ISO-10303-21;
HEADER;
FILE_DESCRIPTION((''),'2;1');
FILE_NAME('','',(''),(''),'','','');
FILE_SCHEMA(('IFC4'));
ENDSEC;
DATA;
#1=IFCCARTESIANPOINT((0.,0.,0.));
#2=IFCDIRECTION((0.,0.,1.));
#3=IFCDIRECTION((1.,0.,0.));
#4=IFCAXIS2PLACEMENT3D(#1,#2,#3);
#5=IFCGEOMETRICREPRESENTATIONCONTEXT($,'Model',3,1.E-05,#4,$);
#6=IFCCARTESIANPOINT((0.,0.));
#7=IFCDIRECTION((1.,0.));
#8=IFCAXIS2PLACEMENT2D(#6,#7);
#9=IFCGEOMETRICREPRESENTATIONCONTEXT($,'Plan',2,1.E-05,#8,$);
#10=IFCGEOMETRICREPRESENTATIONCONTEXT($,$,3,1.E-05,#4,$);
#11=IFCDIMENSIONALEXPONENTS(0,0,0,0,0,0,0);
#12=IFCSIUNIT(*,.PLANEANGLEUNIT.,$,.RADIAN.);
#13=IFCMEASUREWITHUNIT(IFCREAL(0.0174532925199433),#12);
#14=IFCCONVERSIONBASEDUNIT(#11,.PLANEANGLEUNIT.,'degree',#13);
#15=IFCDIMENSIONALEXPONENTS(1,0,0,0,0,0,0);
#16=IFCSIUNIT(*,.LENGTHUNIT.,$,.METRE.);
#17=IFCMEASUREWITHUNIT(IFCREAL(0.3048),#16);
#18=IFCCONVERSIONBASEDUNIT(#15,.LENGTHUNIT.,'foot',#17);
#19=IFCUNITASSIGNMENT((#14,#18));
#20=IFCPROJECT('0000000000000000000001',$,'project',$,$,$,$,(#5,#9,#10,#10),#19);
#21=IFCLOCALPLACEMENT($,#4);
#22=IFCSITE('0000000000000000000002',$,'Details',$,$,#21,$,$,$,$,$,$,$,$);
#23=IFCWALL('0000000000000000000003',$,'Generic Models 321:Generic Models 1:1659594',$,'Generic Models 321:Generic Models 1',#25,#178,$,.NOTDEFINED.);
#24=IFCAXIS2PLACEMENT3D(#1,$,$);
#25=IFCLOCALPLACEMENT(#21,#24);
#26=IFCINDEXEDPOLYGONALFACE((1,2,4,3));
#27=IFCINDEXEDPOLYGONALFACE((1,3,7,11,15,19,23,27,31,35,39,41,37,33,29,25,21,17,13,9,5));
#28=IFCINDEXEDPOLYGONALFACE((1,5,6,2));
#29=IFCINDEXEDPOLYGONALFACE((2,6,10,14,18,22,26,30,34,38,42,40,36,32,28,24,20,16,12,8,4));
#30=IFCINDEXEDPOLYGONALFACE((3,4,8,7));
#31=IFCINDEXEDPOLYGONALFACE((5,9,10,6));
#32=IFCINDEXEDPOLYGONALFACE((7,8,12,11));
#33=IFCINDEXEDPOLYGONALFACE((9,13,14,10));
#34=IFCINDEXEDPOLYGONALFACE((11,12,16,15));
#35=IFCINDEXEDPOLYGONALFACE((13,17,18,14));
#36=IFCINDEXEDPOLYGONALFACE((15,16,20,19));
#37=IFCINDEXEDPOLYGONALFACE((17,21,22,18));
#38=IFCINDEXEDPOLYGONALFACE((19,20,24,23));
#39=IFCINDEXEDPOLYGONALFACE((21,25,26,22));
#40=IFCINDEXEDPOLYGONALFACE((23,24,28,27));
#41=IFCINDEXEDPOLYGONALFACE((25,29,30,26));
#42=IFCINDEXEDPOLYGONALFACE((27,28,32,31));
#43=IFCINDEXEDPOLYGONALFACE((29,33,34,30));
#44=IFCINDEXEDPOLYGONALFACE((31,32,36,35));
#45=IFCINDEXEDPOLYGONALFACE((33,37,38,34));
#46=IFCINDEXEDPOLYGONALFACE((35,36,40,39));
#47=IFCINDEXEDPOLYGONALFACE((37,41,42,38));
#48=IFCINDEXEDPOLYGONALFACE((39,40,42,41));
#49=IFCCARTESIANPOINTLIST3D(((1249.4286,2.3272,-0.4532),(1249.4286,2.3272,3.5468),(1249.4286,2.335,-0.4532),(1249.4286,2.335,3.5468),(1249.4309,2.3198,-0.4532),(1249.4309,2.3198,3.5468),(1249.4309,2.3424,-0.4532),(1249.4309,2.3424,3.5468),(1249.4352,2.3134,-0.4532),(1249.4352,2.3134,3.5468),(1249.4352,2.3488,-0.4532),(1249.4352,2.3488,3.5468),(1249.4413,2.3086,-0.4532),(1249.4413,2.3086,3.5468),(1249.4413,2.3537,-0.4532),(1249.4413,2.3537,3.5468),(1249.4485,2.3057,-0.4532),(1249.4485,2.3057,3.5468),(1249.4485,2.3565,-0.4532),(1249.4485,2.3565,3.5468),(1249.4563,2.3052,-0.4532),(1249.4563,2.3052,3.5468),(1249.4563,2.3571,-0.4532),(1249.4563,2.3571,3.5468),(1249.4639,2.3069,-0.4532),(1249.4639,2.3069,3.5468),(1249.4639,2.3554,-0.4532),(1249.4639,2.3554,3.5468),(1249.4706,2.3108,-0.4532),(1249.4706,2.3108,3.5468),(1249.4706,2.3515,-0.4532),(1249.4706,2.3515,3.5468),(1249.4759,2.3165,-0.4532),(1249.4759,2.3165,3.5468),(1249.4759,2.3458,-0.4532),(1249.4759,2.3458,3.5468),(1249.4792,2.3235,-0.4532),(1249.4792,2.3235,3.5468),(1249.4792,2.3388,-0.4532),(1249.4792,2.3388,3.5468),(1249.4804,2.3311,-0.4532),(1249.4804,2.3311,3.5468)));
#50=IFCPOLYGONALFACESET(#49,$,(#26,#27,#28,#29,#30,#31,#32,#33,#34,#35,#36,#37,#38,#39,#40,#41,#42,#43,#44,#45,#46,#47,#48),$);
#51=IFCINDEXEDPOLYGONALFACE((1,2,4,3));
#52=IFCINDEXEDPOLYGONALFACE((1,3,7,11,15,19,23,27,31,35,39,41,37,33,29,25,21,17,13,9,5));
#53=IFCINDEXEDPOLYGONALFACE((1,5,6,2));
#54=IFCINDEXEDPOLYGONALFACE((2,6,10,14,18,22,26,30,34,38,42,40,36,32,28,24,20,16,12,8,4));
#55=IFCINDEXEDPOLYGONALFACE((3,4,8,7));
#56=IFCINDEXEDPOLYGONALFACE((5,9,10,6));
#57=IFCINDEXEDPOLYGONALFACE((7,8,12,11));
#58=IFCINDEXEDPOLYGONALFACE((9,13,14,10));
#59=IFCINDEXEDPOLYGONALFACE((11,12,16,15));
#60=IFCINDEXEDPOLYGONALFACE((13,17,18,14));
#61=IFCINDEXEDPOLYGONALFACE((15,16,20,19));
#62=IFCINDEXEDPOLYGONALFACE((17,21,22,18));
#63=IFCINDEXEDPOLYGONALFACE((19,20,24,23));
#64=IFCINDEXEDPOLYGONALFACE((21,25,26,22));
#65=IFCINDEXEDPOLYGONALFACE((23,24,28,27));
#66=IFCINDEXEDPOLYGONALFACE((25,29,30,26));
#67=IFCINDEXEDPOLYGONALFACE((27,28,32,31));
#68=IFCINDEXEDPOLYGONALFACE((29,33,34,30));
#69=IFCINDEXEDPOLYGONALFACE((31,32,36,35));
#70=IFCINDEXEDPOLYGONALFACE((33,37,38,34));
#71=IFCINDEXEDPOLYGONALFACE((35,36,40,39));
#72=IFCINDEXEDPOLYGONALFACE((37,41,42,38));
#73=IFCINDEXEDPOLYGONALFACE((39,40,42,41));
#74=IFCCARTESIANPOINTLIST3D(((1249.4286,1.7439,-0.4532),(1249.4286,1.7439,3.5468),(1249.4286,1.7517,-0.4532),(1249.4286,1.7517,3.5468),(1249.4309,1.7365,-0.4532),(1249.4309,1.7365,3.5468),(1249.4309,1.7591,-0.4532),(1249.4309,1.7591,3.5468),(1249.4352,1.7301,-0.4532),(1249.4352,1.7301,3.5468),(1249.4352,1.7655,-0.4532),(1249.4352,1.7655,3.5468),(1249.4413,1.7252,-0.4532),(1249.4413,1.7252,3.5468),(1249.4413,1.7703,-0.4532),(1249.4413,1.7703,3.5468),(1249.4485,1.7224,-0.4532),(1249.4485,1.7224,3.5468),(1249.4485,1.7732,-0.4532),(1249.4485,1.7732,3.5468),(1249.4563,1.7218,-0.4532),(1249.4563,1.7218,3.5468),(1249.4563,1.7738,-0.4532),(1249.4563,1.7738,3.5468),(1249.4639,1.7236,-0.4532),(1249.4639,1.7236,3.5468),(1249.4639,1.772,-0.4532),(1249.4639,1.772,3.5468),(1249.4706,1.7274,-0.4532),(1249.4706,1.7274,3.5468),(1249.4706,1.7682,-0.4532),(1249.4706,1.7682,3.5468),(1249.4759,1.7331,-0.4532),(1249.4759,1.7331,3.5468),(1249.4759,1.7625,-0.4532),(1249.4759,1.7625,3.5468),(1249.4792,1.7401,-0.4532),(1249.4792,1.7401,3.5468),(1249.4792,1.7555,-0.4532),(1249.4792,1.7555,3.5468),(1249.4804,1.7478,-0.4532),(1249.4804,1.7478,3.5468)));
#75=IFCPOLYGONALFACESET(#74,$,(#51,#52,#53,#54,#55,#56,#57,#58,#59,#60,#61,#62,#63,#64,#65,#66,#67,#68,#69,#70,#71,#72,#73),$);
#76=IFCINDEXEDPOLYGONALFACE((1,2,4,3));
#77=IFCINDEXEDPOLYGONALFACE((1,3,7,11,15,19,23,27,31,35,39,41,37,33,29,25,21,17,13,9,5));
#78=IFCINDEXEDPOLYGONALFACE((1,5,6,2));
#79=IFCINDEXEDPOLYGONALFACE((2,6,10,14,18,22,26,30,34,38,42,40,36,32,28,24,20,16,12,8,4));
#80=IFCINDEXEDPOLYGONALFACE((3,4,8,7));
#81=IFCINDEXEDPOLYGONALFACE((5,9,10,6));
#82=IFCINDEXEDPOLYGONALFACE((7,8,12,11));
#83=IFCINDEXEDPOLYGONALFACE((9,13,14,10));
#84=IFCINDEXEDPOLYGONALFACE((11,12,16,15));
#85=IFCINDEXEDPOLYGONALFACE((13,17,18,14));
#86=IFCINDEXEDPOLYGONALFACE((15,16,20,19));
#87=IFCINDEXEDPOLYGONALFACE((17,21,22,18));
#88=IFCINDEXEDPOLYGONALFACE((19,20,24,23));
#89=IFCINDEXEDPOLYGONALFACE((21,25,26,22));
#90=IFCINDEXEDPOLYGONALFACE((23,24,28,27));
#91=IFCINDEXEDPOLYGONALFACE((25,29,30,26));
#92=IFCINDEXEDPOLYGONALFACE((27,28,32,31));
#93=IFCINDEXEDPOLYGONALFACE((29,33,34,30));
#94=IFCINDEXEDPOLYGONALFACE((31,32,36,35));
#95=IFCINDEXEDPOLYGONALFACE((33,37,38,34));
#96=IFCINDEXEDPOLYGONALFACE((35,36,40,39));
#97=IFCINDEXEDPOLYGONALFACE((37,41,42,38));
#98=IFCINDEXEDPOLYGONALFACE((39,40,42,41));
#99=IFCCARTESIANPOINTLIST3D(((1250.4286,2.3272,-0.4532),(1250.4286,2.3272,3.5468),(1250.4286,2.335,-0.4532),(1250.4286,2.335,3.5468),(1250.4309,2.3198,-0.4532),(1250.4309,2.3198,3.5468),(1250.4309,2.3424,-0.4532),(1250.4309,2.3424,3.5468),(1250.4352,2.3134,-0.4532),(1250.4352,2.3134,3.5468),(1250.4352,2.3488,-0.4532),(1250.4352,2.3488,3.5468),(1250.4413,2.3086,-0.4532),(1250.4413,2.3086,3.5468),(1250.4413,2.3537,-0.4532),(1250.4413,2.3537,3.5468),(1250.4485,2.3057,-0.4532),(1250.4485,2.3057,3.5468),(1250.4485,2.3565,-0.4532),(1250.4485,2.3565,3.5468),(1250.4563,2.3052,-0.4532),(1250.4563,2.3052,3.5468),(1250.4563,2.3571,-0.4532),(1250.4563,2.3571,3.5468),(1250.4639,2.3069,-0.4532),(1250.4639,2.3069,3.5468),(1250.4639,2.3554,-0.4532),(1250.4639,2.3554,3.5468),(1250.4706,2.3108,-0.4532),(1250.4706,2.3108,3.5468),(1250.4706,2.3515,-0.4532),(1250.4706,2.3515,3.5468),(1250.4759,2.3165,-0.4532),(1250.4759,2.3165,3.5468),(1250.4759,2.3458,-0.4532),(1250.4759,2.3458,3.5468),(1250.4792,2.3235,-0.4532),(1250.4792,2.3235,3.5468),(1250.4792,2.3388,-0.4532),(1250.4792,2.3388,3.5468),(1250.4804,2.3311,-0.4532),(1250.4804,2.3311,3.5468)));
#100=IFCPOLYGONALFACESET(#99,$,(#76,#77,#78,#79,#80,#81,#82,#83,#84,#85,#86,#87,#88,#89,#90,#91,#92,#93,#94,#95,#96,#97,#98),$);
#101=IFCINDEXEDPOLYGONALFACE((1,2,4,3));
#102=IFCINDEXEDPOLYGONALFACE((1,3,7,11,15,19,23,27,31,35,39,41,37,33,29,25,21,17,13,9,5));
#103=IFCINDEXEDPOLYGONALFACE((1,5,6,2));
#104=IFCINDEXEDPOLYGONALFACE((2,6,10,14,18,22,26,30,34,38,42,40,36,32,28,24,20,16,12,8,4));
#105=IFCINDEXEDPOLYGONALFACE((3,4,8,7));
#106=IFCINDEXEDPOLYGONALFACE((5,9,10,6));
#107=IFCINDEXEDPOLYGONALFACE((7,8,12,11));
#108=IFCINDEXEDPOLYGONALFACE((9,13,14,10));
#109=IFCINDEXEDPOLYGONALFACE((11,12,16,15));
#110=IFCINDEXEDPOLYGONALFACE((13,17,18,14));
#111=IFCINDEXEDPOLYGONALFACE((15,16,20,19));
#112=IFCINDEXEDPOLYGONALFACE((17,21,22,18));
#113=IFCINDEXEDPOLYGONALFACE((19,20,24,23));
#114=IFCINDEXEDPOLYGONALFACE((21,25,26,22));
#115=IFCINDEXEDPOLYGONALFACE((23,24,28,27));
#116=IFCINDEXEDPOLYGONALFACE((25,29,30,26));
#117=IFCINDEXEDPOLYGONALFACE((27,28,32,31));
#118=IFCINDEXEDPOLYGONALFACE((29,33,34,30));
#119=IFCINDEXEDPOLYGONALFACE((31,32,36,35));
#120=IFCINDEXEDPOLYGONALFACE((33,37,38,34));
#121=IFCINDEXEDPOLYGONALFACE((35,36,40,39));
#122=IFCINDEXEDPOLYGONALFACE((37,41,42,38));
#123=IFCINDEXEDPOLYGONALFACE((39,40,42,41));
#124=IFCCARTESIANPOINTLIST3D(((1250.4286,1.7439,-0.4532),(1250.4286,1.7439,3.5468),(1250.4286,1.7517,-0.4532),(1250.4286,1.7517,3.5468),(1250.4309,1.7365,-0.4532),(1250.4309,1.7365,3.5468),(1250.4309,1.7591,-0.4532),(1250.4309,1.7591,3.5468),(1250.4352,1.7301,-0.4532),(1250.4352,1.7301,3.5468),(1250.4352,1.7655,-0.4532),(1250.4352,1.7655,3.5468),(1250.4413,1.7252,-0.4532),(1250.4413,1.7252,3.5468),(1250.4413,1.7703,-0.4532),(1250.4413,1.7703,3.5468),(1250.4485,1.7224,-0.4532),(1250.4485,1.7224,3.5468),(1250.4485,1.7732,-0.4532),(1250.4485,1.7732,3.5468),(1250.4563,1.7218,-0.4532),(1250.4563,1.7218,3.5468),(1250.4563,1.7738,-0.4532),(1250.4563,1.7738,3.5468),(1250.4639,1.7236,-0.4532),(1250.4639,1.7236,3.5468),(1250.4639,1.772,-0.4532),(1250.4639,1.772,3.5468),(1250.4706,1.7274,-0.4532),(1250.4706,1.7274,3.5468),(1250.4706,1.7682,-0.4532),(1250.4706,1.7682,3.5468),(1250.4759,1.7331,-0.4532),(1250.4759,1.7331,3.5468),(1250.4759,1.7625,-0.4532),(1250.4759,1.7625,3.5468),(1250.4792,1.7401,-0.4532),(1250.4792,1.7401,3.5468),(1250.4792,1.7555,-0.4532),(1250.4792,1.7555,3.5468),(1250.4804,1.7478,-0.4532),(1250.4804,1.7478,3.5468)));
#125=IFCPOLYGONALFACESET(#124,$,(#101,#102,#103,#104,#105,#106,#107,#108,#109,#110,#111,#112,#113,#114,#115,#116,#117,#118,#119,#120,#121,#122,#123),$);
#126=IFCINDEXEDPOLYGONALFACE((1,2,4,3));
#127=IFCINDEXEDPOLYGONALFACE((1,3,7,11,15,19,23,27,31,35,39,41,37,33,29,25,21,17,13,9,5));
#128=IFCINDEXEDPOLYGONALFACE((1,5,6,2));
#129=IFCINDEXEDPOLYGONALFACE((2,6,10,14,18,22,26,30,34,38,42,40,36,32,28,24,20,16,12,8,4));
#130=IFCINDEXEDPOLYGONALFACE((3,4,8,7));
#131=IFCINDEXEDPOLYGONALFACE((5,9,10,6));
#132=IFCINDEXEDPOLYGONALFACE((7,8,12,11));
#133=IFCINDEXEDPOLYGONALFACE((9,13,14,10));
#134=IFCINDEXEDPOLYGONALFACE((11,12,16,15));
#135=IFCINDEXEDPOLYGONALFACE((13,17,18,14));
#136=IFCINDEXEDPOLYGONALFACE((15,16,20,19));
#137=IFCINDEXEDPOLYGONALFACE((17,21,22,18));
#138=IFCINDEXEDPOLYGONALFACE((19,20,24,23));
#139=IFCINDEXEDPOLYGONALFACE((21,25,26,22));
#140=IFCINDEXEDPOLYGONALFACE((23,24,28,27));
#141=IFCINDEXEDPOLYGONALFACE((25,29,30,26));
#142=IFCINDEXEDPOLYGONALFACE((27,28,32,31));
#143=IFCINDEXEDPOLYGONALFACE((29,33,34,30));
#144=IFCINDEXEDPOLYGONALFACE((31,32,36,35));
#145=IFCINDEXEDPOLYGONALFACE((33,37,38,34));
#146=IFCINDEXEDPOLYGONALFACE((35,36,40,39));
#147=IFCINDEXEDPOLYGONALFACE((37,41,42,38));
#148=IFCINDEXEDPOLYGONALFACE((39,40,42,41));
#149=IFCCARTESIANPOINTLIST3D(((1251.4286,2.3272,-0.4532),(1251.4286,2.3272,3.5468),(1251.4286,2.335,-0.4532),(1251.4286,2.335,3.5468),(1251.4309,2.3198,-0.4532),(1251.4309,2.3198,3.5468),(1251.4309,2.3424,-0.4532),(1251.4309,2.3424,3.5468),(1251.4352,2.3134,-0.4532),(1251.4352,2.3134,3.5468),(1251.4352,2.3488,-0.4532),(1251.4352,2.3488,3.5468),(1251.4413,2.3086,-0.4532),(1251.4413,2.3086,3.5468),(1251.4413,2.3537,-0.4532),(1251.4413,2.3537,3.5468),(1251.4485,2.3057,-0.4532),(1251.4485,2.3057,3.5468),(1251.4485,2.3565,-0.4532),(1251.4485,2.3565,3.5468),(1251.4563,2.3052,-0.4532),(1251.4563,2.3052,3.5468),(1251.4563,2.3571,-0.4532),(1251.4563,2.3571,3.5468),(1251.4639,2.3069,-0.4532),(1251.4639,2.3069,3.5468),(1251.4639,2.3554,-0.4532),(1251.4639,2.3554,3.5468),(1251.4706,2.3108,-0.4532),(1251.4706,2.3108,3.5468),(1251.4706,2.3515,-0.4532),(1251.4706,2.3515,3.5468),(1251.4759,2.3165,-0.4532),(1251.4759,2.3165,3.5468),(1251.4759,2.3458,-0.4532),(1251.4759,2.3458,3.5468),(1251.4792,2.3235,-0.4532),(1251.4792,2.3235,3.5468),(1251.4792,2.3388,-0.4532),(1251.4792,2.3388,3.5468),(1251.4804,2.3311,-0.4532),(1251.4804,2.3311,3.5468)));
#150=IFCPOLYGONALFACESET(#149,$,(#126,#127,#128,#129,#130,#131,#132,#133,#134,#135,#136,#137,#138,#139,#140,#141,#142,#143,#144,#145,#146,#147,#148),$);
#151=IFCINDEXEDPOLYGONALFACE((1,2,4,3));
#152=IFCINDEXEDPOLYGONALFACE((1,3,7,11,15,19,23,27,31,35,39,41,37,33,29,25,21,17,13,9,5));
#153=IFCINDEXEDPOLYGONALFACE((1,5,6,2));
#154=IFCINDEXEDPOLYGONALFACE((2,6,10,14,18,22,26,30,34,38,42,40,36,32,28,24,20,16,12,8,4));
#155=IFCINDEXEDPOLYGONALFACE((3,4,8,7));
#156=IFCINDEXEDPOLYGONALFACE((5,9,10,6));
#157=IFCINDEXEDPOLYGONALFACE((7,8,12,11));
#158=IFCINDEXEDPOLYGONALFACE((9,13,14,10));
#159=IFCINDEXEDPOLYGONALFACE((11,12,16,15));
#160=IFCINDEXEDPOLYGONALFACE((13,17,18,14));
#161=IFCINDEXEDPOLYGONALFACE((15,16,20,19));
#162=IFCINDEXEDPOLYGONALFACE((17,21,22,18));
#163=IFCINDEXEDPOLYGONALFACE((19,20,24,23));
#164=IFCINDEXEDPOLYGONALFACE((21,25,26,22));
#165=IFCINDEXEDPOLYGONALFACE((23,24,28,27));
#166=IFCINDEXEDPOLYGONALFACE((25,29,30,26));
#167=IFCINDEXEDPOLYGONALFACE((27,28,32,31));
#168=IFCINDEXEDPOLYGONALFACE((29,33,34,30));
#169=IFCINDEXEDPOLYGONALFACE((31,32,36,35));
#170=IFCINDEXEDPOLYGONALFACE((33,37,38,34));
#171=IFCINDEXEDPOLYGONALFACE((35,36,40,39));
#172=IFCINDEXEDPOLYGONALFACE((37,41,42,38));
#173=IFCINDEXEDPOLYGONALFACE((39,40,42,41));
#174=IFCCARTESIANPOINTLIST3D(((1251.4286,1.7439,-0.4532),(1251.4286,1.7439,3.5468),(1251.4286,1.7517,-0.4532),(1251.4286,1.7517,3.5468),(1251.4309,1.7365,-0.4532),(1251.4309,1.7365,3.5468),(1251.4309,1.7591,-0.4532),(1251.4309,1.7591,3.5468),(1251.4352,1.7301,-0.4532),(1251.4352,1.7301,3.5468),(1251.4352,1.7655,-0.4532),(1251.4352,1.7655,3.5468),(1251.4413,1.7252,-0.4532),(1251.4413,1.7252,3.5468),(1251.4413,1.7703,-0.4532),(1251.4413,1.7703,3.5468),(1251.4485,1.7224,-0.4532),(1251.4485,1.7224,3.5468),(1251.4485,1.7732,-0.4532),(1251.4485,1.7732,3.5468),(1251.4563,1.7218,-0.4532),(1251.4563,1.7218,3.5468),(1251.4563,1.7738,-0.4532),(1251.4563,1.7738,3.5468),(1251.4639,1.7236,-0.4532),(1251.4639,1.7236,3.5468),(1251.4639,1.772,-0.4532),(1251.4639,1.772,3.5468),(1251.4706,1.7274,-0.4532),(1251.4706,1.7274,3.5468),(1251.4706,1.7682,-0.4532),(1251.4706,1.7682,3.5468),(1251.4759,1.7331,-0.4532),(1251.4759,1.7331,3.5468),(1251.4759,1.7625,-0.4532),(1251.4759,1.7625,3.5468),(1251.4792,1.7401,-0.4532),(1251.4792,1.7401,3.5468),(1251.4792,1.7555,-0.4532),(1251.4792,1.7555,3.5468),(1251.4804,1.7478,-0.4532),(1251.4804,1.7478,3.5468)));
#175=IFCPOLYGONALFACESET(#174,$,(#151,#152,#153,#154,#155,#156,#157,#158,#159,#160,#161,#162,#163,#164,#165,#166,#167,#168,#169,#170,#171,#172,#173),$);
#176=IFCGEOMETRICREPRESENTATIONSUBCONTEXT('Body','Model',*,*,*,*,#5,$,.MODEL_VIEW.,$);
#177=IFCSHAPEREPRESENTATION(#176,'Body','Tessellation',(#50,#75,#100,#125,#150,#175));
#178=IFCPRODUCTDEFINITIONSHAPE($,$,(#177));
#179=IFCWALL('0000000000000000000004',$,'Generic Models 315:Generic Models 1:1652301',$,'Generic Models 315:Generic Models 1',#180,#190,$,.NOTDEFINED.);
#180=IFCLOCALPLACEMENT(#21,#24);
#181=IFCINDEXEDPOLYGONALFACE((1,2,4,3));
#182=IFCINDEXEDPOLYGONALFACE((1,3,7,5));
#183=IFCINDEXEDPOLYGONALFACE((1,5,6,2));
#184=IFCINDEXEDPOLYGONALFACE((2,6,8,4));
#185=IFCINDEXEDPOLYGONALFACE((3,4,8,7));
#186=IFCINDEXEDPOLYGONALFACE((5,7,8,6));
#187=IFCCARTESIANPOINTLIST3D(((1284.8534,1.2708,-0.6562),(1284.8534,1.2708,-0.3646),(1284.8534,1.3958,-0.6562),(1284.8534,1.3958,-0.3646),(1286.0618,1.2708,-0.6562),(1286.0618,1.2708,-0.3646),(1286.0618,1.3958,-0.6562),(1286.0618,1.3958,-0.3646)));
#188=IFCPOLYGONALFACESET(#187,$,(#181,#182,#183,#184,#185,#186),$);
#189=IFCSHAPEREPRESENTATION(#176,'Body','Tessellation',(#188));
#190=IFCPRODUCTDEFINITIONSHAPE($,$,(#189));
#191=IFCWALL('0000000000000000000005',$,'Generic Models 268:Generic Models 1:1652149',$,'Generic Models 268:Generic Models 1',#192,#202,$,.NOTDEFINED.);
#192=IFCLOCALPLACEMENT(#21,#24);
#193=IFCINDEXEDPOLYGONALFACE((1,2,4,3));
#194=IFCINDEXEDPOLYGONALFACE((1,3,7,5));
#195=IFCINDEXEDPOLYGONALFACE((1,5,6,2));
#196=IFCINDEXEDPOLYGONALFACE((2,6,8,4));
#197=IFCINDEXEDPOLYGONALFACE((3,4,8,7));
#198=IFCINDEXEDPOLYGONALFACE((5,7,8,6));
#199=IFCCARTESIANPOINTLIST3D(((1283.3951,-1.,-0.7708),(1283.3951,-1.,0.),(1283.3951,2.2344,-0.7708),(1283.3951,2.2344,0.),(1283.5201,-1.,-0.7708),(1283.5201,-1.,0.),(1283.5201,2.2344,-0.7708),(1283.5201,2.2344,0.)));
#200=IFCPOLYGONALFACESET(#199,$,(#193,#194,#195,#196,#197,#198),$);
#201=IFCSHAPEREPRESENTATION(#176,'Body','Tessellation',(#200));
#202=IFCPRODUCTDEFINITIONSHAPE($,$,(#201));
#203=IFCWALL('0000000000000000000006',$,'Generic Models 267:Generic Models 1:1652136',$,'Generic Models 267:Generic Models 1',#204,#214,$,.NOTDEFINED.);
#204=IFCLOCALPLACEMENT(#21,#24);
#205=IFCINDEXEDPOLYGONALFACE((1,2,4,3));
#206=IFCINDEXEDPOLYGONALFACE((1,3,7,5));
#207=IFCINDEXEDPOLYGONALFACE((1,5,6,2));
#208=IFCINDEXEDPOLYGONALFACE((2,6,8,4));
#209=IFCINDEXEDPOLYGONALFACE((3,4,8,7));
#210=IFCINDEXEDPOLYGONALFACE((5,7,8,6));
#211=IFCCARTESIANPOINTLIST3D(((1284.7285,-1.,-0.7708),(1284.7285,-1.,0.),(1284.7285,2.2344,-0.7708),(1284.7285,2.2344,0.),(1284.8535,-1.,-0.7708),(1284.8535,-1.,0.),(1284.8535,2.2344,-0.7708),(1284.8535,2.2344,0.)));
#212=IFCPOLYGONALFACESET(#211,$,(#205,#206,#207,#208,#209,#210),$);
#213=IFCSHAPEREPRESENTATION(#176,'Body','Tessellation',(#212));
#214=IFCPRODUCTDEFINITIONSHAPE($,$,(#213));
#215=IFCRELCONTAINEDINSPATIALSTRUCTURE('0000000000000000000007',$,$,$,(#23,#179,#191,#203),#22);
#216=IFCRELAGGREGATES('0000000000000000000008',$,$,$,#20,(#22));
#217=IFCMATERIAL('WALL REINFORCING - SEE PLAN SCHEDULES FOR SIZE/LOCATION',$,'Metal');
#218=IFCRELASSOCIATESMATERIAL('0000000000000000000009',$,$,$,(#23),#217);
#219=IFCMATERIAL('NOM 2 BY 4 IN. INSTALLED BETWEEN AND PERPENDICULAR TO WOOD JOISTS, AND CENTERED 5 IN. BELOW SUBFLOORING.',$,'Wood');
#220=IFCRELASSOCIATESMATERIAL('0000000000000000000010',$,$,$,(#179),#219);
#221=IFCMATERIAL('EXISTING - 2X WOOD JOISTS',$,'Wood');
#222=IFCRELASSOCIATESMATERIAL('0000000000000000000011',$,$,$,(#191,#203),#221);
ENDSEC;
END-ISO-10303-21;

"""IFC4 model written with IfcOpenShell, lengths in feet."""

from ifc_helpers import new_model, entity, si_unit, converted_unit, frame, frame_2d, origin_with_axes, origin_2d_with_axis, place, context, subcontext, project, spatial, rectangle, circle, extrude, material, element, save


model = new_model("IFC4")

# Units and contexts
model_context = context("Model", 3, precision=1e-05, world=origin_with_axes())
plan_context = context("Plan", 2, precision=1e-05, world=origin_2d_with_axis())
context_of_model = context(None, 3, precision=1e-05, world=origin_with_axes())
body_context = subcontext(model_context, "Body", "Model", "MODEL_VIEW")
ifc_project = project(units=[converted_unit("PLANEANGLEUNIT", "degree", entity("IfcReal", 0.0174532925199433), si_unit("PLANEANGLEUNIT", "RADIAN"), dimensions=[0, 0, 0, 0, 0, 0, 0]), converted_unit("LENGTHUNIT", "foot", entity("IfcReal", 0.3048), si_unit("LENGTHUNIT", "METRE"), dimensions=[1, 0, 0, 0, 0, 0, 0])], contexts=[model_context, plan_context, context_of_model, context_of_model])

# Site
site_placement = place(None, origin_with_axes())
site = spatial("IfcSite", under=ifc_project, at=site_placement, Name="Details")

# Walls
ifc_material_1 = material(Name="WALL REINFORCING - SEE PLAN SCHEDULES FOR SIZE/LOCATION", Category="Metal")
wall_1_placement = place(site_placement, frame((1249.4283, 1.7218, -0.4532), z_axis=(0.0, 0.0, 1.0), x_axis=(1.0, 0.0, 0.0)))
element("IfcWall", 1, at=wall_1_placement, inside=site, material=ifc_material_1, Name="Generic Models 321:Generic Models 1:1659594", ObjectType="Generic Models 321:Generic Models 1", PredefinedType="NOTDEFINED", context=body_context, shape_type="SweptSolid", body=[
    extrude(circle(Radius=0.026, at=frame_2d((0.0, 0.0), x_axis=(1.0, 0.0))), frame((0.026, 0.6094, 0.0)), (0.0, 0.0, 1.0), 4.0),
    extrude(circle(Radius=0.026, at=frame_2d((0.0, 0.0), x_axis=(1.0, 0.0))), frame((0.026, 0.026, 0.0)), (0.0, 0.0, 1.0), 4.0),
    extrude(circle(Radius=0.026, at=frame_2d((0.0, 0.0), x_axis=(1.0, 0.0))), frame((1.026, 0.6094, 0.0)), (0.0, 0.0, 1.0), 4.0),
    extrude(circle(Radius=0.026, at=frame_2d((0.0, 0.0), x_axis=(1.0, 0.0))), frame((1.026, 0.026, 0.0)), (0.0, 0.0, 1.0), 4.0),
    extrude(circle(Radius=0.026, at=frame_2d((0.0, 0.0), x_axis=(1.0, 0.0))), frame((2.026, 0.6094, 0.0)), (0.0, 0.0, 1.0), 4.0),
    extrude(circle(Radius=0.026, at=frame_2d((0.0, 0.0), x_axis=(1.0, 0.0))), frame((2.026, 0.026, 0.0)), (0.0, 0.0, 1.0), 4.0),
])
ifc_material_2 = material(Name="NOM 2 BY 4 IN. INSTALLED BETWEEN AND PERPENDICULAR TO WOOD JOISTS, AND CENTERED 5 IN. BELOW SUBFLOORING.", Category="Wood")
wall_2_placement = place(site_placement, frame((1284.8534, 1.2708, -0.6562), z_axis=(0.0, 0.0, 1.0), x_axis=(1.0, 0.0, 0.0)))
element("IfcWall", 2, at=wall_2_placement, inside=site, material=ifc_material_2, Name="Generic Models 315:Generic Models 1:1652301", ObjectType="Generic Models 315:Generic Models 1", PredefinedType="NOTDEFINED", context=body_context, shape_type="SweptSolid", body=[
    extrude(rectangle(XDim=0.125, YDim=1.2083, at=frame_2d((0.0, 0.0), x_axis=(1.0, 0.0))), frame((0.6042, 0.0625, 0.0), z_axis=(0.0, 0.0, 1.0), x_axis=(0.0, 1.0, 0.0)), (0.0, 0.0, 1.0), 0.2917),
])
ifc_material_3 = material(Name="EXISTING - 2X WOOD JOISTS", Category="Wood")
wall_3_placement = place(site_placement, frame((1283.3951, -1.0, -0.7708), z_axis=(0.0, 0.0, 1.0), x_axis=(0.0, 1.0, 0.0)))
element("IfcWall", 3, at=wall_3_placement, inside=site, material=ifc_material_3, Name="Generic Models 268:Generic Models 1:1652149", ObjectType="Generic Models 268:Generic Models 1", PredefinedType="NOTDEFINED", context=body_context, shape_type="SweptSolid", body=[
    extrude(rectangle(XDim=3.2344, YDim=0.125, at=frame_2d((0.0, 0.0), x_axis=(1.0, 0.0))), frame((1.6172, -0.0625, 0.0)), (0.0, 0.0, 1.0), 0.7708),
])
wall_4_placement = place(site_placement, frame((1284.7285, -1.0, -0.7708), z_axis=(0.0, 0.0, 1.0), x_axis=(0.0, 1.0, 0.0)))
element("IfcWall", 4, at=wall_4_placement, inside=site, material=ifc_material_3, Name="Generic Models 267:Generic Models 1:1652136", ObjectType="Generic Models 267:Generic Models 1", PredefinedType="NOTDEFINED", context=body_context, shape_type="SweptSolid", body=[
    extrude(rectangle(XDim=3.2344, YDim=0.125, at=frame_2d((0.0, 0.0), x_axis=(1.0, 0.0))), frame((1.6172, -0.0625, 0.0)), (0.0, 0.0, 1.0), 0.7708),
])

save(model, "model.ifc")
